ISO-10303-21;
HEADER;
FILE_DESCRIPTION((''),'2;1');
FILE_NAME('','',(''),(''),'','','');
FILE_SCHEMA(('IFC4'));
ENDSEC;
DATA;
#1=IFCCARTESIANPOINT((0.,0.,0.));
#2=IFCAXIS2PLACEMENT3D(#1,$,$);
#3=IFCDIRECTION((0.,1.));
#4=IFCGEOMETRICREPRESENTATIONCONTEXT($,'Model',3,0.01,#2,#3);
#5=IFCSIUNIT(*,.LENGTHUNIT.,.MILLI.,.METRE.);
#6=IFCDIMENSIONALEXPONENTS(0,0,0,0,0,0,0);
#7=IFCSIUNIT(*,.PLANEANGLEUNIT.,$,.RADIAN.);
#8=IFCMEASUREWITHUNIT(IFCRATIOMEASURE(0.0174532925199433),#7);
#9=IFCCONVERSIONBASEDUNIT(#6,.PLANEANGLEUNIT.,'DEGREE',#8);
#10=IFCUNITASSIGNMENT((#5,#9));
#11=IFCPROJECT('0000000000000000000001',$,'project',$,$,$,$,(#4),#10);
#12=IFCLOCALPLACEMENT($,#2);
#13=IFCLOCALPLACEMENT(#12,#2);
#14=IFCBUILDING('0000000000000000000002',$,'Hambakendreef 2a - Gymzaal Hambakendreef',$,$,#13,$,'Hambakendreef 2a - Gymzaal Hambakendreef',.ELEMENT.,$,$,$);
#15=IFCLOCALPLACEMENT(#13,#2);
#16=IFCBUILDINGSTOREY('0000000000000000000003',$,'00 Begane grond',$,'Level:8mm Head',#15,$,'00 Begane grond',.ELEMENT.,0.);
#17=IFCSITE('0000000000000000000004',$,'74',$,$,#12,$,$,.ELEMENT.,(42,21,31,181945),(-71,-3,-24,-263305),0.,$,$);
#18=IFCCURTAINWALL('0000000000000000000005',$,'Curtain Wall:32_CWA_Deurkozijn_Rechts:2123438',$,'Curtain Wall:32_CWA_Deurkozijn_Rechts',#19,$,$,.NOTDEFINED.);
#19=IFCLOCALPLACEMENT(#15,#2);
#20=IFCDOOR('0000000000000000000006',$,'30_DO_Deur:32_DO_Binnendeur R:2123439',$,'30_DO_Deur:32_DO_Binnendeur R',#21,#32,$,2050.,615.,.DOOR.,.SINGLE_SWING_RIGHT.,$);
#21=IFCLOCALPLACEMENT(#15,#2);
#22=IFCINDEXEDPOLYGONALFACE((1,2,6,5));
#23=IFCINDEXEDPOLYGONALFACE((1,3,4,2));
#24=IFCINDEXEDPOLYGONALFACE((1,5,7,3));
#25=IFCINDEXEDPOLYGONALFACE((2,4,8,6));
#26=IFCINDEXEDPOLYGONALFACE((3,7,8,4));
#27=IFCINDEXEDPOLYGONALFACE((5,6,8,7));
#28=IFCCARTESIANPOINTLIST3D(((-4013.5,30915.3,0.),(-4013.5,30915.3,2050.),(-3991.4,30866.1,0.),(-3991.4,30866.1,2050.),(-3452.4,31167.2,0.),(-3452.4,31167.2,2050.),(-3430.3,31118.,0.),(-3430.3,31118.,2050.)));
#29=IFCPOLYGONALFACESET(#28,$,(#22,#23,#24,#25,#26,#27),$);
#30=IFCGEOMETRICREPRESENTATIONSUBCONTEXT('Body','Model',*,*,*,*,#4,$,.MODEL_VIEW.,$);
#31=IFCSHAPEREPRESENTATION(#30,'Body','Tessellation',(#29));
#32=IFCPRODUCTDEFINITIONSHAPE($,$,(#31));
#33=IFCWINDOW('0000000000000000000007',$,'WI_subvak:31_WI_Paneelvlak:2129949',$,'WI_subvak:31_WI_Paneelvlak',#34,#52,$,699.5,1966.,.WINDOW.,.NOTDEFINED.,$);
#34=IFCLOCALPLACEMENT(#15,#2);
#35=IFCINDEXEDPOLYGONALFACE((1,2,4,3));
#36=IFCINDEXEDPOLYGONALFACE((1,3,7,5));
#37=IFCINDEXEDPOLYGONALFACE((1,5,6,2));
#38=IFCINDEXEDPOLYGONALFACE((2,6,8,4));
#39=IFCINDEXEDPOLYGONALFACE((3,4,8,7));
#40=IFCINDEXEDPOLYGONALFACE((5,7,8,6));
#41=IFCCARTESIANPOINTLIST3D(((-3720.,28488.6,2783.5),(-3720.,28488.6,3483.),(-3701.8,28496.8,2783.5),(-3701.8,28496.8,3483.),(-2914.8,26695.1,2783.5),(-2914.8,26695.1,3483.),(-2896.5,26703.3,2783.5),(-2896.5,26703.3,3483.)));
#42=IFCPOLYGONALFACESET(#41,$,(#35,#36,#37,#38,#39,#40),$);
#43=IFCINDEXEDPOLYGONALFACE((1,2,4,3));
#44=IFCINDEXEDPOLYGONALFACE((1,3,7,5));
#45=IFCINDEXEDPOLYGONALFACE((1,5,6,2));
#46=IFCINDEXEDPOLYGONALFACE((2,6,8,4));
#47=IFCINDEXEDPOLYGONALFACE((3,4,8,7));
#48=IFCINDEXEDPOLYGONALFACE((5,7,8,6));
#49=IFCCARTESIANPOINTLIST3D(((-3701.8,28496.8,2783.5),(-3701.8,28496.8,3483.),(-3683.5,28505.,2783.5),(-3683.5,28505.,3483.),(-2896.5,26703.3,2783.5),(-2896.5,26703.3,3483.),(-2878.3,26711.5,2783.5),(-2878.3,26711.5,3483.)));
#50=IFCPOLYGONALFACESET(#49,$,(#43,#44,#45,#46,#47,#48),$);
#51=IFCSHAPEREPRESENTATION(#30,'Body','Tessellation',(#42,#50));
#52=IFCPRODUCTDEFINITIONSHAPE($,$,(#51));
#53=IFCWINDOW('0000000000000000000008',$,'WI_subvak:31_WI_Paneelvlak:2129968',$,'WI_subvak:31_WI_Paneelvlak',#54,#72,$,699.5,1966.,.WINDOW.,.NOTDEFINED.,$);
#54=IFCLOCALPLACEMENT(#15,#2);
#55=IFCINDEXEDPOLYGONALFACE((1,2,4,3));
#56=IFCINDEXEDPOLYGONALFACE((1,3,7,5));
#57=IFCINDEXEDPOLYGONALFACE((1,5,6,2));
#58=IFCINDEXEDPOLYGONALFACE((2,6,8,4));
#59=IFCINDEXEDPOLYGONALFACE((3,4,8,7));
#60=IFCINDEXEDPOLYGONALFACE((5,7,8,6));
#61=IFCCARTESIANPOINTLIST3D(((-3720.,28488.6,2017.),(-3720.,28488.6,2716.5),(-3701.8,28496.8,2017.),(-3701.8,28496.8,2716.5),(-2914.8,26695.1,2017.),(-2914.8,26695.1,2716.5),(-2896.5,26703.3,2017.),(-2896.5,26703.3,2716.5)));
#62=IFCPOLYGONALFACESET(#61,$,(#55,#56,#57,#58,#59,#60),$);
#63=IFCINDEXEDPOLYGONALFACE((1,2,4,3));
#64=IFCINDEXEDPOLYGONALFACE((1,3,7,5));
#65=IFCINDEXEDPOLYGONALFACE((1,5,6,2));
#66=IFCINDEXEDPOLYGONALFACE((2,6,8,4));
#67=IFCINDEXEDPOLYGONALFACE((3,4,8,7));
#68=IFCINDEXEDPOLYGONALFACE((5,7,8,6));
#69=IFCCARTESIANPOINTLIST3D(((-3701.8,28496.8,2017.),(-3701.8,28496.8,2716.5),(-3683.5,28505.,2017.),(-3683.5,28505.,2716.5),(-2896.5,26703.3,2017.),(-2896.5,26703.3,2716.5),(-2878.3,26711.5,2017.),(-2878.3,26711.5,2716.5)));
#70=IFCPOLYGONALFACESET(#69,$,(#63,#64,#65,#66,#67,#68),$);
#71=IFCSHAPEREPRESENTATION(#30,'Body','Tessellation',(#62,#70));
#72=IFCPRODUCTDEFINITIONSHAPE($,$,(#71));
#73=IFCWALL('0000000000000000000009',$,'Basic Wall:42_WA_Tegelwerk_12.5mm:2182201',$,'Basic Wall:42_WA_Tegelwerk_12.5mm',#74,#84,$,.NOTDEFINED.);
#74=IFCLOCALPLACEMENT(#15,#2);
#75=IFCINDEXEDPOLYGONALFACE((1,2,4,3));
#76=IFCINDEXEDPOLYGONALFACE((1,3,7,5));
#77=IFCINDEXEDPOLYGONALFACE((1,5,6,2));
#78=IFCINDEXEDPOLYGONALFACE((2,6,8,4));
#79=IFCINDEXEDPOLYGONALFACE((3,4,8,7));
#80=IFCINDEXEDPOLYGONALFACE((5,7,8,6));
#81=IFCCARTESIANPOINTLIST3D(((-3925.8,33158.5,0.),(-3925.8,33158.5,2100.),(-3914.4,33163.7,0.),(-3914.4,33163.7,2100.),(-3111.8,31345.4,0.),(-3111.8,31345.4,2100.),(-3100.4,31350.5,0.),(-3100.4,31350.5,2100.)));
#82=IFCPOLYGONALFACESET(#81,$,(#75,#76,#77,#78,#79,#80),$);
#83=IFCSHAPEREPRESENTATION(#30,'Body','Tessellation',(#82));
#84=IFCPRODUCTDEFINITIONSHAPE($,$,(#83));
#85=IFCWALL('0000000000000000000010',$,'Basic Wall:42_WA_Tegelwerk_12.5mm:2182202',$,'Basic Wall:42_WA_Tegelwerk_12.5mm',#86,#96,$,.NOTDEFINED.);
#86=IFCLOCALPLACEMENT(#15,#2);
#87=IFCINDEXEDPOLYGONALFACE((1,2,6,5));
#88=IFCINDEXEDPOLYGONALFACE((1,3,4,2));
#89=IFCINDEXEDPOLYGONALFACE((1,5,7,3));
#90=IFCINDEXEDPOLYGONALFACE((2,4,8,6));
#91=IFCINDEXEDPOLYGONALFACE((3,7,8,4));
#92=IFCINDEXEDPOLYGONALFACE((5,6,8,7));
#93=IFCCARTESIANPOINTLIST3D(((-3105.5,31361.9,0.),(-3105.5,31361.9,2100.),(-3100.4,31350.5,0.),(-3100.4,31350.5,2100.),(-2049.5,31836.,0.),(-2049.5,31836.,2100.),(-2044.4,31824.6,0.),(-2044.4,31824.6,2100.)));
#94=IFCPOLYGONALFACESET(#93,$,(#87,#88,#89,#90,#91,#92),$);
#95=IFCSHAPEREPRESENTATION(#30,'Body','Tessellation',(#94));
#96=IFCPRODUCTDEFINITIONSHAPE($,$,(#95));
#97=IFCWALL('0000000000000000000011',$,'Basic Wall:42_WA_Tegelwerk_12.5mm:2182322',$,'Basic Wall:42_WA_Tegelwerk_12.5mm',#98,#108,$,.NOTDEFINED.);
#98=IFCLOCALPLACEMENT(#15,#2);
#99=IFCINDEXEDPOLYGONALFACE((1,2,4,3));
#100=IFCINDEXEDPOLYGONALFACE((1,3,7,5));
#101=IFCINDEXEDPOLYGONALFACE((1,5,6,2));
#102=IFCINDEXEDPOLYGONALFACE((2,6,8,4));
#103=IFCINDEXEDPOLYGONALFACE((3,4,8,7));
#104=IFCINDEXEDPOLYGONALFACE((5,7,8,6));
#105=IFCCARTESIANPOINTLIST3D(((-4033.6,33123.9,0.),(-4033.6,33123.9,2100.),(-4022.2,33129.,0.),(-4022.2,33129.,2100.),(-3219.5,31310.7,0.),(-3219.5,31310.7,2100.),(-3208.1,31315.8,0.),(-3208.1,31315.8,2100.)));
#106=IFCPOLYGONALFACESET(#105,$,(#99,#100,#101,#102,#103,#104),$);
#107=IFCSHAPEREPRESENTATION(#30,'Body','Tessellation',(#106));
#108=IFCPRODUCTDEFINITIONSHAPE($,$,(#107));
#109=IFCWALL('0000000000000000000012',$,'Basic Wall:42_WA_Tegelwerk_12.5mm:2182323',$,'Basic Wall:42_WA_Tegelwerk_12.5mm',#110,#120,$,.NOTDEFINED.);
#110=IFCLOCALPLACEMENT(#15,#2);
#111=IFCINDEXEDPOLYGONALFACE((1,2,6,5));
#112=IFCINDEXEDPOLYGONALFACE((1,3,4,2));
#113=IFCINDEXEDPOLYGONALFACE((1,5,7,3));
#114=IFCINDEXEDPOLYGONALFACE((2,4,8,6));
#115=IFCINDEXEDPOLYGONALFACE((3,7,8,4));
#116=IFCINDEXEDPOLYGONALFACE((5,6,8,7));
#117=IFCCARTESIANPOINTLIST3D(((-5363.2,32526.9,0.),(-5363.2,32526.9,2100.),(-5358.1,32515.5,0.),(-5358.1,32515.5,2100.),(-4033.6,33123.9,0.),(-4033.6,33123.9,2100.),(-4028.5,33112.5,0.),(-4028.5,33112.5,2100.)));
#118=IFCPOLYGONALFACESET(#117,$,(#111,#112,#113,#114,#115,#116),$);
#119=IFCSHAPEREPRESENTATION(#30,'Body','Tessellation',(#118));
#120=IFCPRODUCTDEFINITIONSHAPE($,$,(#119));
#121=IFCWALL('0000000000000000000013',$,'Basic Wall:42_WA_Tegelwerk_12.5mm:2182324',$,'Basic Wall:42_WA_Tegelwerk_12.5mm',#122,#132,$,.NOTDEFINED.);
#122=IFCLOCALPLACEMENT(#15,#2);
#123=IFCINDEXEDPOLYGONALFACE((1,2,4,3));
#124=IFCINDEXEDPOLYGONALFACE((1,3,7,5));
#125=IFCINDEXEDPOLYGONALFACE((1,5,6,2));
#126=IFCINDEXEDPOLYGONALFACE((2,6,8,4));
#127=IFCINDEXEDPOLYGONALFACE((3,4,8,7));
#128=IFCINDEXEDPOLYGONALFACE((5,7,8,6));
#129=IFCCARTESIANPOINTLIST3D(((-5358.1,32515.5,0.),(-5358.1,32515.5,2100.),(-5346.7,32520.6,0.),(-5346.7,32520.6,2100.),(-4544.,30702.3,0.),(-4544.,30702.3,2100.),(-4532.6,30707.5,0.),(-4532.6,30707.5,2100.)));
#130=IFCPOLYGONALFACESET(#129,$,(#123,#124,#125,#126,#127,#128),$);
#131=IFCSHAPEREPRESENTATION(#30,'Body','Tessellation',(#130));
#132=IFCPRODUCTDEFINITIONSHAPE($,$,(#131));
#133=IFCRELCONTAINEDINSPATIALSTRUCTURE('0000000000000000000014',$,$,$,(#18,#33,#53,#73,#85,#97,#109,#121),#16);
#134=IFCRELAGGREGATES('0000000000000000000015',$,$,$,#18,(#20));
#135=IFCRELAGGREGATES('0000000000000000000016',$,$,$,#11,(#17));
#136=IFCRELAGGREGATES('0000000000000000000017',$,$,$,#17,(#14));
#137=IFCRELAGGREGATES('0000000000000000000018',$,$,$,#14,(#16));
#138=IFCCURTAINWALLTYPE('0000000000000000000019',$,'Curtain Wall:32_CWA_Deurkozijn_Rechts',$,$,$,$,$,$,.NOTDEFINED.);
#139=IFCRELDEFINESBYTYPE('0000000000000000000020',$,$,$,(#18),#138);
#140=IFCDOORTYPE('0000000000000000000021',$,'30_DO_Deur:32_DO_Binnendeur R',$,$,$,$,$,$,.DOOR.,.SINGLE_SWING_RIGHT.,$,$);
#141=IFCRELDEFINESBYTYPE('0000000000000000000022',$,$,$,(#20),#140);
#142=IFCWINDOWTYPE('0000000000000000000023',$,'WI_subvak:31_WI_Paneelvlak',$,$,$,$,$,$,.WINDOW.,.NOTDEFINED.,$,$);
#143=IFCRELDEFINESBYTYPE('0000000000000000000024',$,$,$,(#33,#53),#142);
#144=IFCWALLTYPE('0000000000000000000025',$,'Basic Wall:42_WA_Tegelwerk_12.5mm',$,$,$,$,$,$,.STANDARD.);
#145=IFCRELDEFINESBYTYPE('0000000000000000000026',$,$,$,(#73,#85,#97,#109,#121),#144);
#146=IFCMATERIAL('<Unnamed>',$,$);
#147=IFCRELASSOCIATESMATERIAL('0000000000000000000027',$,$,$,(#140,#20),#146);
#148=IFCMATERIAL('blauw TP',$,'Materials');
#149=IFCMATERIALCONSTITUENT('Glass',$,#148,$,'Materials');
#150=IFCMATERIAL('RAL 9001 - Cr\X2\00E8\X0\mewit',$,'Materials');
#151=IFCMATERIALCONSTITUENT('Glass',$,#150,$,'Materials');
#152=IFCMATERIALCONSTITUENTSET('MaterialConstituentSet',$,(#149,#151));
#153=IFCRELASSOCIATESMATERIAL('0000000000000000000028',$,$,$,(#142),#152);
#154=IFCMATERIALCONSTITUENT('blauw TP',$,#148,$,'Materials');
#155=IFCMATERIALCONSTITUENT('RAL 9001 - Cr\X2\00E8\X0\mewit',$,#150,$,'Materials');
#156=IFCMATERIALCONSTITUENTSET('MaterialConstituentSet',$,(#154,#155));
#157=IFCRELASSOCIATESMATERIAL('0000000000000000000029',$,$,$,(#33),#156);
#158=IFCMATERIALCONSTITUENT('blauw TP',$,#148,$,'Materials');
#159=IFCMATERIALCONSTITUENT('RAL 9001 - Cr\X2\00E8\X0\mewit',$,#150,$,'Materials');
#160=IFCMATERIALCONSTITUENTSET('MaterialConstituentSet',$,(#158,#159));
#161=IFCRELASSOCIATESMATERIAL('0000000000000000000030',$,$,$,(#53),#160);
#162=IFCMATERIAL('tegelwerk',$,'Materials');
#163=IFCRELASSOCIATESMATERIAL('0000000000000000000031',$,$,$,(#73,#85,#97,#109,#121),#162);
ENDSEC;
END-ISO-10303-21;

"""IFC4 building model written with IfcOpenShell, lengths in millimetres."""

from ifc_helpers import new_model, entity, si_unit, converted_unit, direction, frame, origin, place, context, subcontext, project, spatial, indexed_curve, outline, extrude, source, transform, mapped, material, constituent, constituent_set, type_object, type_shapes, element, aggregate, save


model = new_model("IFC4")

# Units and contexts
model_context = context("Model", 3, precision=0.01, world=origin(), true_north=direction((0.0, 1.0)))
body_context = subcontext(model_context, "Body", "Model", "MODEL_VIEW")
ifc_project = project(units=[si_unit("LENGTHUNIT", "METRE", prefix="MILLI"), converted_unit("PLANEANGLEUNIT", "DEGREE", entity("IfcRatioMeasure", 0.0174532925199433), si_unit("PLANEANGLEUNIT", "RADIAN"), dimensions=[0, 0, 0, 0, 0, 0, 0])], contexts=[model_context])

# Site, building, storey
site_placement = place(None, origin())
site = spatial("IfcSite", under=ifc_project, at=site_placement, Name="74", CompositionType="ELEMENT", RefLatitude=(42, 21, 31, 181945), RefLongitude=(-71, -3, -24, -263305), RefElevation=0.0)
building_placement = place(site_placement, origin())
building = spatial("IfcBuilding", under=site, at=building_placement, Name="Hambakendreef 2a - Gymzaal Hambakendreef", LongName="Hambakendreef 2a - Gymzaal Hambakendreef", CompositionType="ELEMENT")
storey_placement = place(building_placement, origin())
storey = spatial("IfcBuildingStorey", under=building, at=storey_placement, Name="00 Begane grond", ObjectType="Level:8mm Head", LongName="00 Begane grond", CompositionType="ELEMENT", Elevation=0.0)

# Curtain wall
curtain_wall_type_1 = type_object("IfcCurtainWallType", Name="Curtain Wall:32_CWA_Deurkozijn_Rechts", PredefinedType="NOTDEFINED")
curtain_wall_1_placement = place(storey_placement, origin())
curtain_wall_1 = element("IfcCurtainWall", 1, at=curtain_wall_1_placement, inside=storey, type_object=curtain_wall_type_1, Name="Curtain Wall:32_CWA_Deurkozijn_Rechts:2123438", ObjectType="Curtain Wall:32_CWA_Deurkozijn_Rechts", PredefinedType="NOTDEFINED")

# Door
ifc_material_1 = material(Name="<Unnamed>")
door_type_1 = type_object("IfcDoorType", Name="30_DO_Deur:32_DO_Binnendeur R", OperationType="SINGLE_SWING_RIGHT", PredefinedType="DOOR", material=ifc_material_1)
shared_shape_1 = source(origin(), body_context, "Body", "SweptSolid", [
    extrude(outline(indexed_curve([(-27.0, -307.5), (27.0, -307.5), (27.0, 307.5), (-27.0, 307.5), (-27.0, -307.5)], self_intersect=False)), frame((0.0, 0.0, 0.0), z_axis=(0.0, 0.0, 1.0), x_axis=(0.0, 1.0, 0.0)), (0.0, 0.0, 1.0), 2050.0),
])
type_shapes(door_type_1, [shared_shape_1])
door_1_placement = place(curtain_wall_1_placement, frame((-3721.9, 31016.7, 0.0), z_axis=(0.0, 0.0, 1.0), x_axis=(0.91227, 0.40959, 0.0)))
door_1 = element("IfcDoor", 2, at=door_1_placement, type_object=door_type_1, material=ifc_material_1, Name="30_DO_Deur:32_DO_Binnendeur R:2123439", ObjectType="30_DO_Deur:32_DO_Binnendeur R", OperationType="SINGLE_SWING_RIGHT", OverallHeight=2050.0, OverallWidth=615.0, PredefinedType="DOOR", context=body_context, shape_type="MappedRepresentation", body=[
    mapped(shared_shape_1, transform((0.0, 0.0, 0.0), scale=1.0)),
])
aggregate(curtain_wall_1, [door_1])

# Windows
ifc_material_2 = material(Name="blauw TP", Category="Materials")
ifc_constituent_1 = constituent(ifc_material_2, Name="blauw TP", Category="Materials")
ifc_material_3 = material(Name="RAL 9001 - Crèmewit", Category="Materials")
ifc_constituent_2 = constituent(ifc_material_3, Name="RAL 9001 - Crèmewit", Category="Materials")
ifc_constituent_set_1 = constituent_set(constituents=[ifc_constituent_1, ifc_constituent_2], Name="MaterialConstituentSet")
ifc_constituent_3 = constituent(ifc_material_2, Name="Glass", Category="Materials")
ifc_constituent_4 = constituent(ifc_material_3, Name="Glass", Category="Materials")
ifc_constituent_set_2 = constituent_set(constituents=[ifc_constituent_3, ifc_constituent_4], Name="MaterialConstituentSet")
window_type = type_object("IfcWindowType", Name="WI_subvak:31_WI_Paneelvlak", PartitioningType="NOTDEFINED", PredefinedType="WINDOW", material=ifc_constituent_set_2)
shared_shape_2 = source(origin(), body_context, "Body", "SweptSolid", [
    extrude(outline(indexed_curve([(-983.0, -10.0), (983.0, -10.0), (983.0, 10.0), (-983.0, 10.0), (-983.0, -10.0)], self_intersect=False)), frame((0.0, -10.0, 0.0)), (0.0, 0.0, 1.0), 699.5),
    extrude(outline(indexed_curve([(-983.0, -10.0), (983.0, -10.0), (983.0, 10.0), (-983.0, 10.0), (-983.0, -10.0)], self_intersect=False)), frame((0.0, 10.0, 0.0)), (0.0, 0.0, 1.0), 699.5),
])
type_shapes(window_type, [shared_shape_2])
window_1_placement = place(storey_placement, frame((-3299.2, 27600.1, 2783.5), z_axis=(0.0, 0.0, 1.0), x_axis=(0.40959, -0.91227, 0.0)))
element("IfcWindow", 3, at=window_1_placement, inside=storey, type_object=window_type, material=ifc_constituent_set_1, Name="WI_subvak:31_WI_Paneelvlak:2129949", ObjectType="WI_subvak:31_WI_Paneelvlak", OverallHeight=699.5, OverallWidth=1966.0, PartitioningType="NOTDEFINED", PredefinedType="WINDOW", context=body_context, shape_type="MappedRepresentation", body=[
    mapped(shared_shape_2, transform((0.0, 0.0, 0.0), scale=1.0)),
])
ifc_constituent_5 = constituent(ifc_material_2, Name="blauw TP", Category="Materials")
ifc_constituent_6 = constituent(ifc_material_3, Name="RAL 9001 - Crèmewit", Category="Materials")
ifc_constituent_set_3 = constituent_set(constituents=[ifc_constituent_5, ifc_constituent_6], Name="MaterialConstituentSet")
window_2_placement = place(storey_placement, frame((-3299.2, 27600.1, 2017.0), z_axis=(0.0, 0.0, 1.0), x_axis=(0.40959, -0.91227, 0.0)))
element("IfcWindow", 4, at=window_2_placement, inside=storey, type_object=window_type, material=ifc_constituent_set_3, Name="WI_subvak:31_WI_Paneelvlak:2129968", ObjectType="WI_subvak:31_WI_Paneelvlak", OverallHeight=699.5, OverallWidth=1966.0, PartitioningType="NOTDEFINED", PredefinedType="WINDOW", context=body_context, shape_type="MappedRepresentation", body=[
    mapped(shared_shape_2, transform((0.0, 0.0, 0.0), scale=1.0)),
])

# Walls
ifc_material_4 = material(Name="tegelwerk", Category="Materials")
wall_type = type_object("IfcWallType", Name="Basic Wall:42_WA_Tegelwerk_12.5mm", PredefinedType="STANDARD")
wall_1_placement = place(storey_placement, frame((-3106.1, 31348.0, 0.0), z_axis=(0.0, 0.0, 1.0), x_axis=(-0.40959, 0.91227, 0.0)))
element("IfcWall", 5, at=wall_1_placement, inside=storey, type_object=wall_type, material=ifc_material_4, Name="Basic Wall:42_WA_Tegelwerk_12.5mm:2182201", ObjectType="Basic Wall:42_WA_Tegelwerk_12.5mm", PredefinedType="NOTDEFINED", context=body_context, shape_type="SweptSolid", body=[
    extrude(outline(indexed_curve([(1987.5, 6.3), (0.0, 6.2), (0.0, -6.2), (1987.5, -6.2), (1987.5, 6.3)], self_intersect=False)), origin(), (0.0, 0.0, 1.0), 2100.0),
])
wall_2_placement = place(storey_placement, frame((-2047.0, 31830.3, 0.0), z_axis=(0.0, 0.0, 1.0), x_axis=(-0.91227, -0.40959, 0.0)))
element("IfcWall", 6, at=wall_2_placement, inside=storey, type_object=wall_type, material=ifc_material_4, Name="Basic Wall:42_WA_Tegelwerk_12.5mm:2182202", ObjectType="Basic Wall:42_WA_Tegelwerk_12.5mm", PredefinedType="NOTDEFINED", context=body_context, shape_type="SweptSolid", body=[
    extrude(outline(indexed_curve([(1157.5, 6.3), (0.0, 6.2), (0.0, -6.2), (1157.5, -6.2), (1157.5, 6.3)], self_intersect=False)), origin(), (0.0, 0.0, 1.0), 2100.0),
])
wall_3_placement = place(storey_placement, frame((-4027.9, 33126.4, 0.0), z_axis=(0.0, 0.0, 1.0), x_axis=(0.40959, -0.91227, 0.0)))
element("IfcWall", 7, at=wall_3_placement, inside=storey, type_object=wall_type, material=ifc_material_4, Name="Basic Wall:42_WA_Tegelwerk_12.5mm:2182322", ObjectType="Basic Wall:42_WA_Tegelwerk_12.5mm", PredefinedType="NOTDEFINED", context=body_context, shape_type="SweptSolid", body=[
    extrude(outline(indexed_curve([(1987.5, 6.3), (0.0, 6.2), (0.0, -6.2), (1987.5, -6.2), (1987.5, 6.3)], self_intersect=False)), origin(), (0.0, 0.0, 1.0), 2100.0),
])
wall_4_placement = place(storey_placement, frame((-5360.7, 32521.2, 0.0), z_axis=(0.0, 0.0, 1.0), x_axis=(0.91227, 0.40959, 0.0)))
element("IfcWall", 8, at=wall_4_placement, inside=storey, type_object=wall_type, material=ifc_material_4, Name="Basic Wall:42_WA_Tegelwerk_12.5mm:2182323", ObjectType="Basic Wall:42_WA_Tegelwerk_12.5mm", PredefinedType="NOTDEFINED", context=body_context, shape_type="SweptSolid", body=[
    extrude(outline(indexed_curve([(1457.5, 6.2), (0.0, 6.2), (0.0, -6.2), (1457.5, -6.3), (1457.5, 6.2)], self_intersect=False)), origin(), (0.0, 0.0, 1.0), 2100.0),
])
wall_5_placement = place(storey_placement, frame((-4538.3, 30704.9, 0.0), z_axis=(0.0, 0.0, 1.0), x_axis=(-0.40959, 0.91227, 0.0)))
element("IfcWall", 9, at=wall_5_placement, inside=storey, type_object=wall_type, material=ifc_material_4, Name="Basic Wall:42_WA_Tegelwerk_12.5mm:2182324", ObjectType="Basic Wall:42_WA_Tegelwerk_12.5mm", PredefinedType="NOTDEFINED", context=body_context, shape_type="SweptSolid", body=[
    extrude(outline(indexed_curve([(1987.5, 6.3), (0.0, 6.2), (0.0, -6.2), (1987.5, -6.2), (1987.5, 6.3)], self_intersect=False)), origin(), (0.0, 0.0, 1.0), 2100.0),
])

save(model, "model.ifc")
